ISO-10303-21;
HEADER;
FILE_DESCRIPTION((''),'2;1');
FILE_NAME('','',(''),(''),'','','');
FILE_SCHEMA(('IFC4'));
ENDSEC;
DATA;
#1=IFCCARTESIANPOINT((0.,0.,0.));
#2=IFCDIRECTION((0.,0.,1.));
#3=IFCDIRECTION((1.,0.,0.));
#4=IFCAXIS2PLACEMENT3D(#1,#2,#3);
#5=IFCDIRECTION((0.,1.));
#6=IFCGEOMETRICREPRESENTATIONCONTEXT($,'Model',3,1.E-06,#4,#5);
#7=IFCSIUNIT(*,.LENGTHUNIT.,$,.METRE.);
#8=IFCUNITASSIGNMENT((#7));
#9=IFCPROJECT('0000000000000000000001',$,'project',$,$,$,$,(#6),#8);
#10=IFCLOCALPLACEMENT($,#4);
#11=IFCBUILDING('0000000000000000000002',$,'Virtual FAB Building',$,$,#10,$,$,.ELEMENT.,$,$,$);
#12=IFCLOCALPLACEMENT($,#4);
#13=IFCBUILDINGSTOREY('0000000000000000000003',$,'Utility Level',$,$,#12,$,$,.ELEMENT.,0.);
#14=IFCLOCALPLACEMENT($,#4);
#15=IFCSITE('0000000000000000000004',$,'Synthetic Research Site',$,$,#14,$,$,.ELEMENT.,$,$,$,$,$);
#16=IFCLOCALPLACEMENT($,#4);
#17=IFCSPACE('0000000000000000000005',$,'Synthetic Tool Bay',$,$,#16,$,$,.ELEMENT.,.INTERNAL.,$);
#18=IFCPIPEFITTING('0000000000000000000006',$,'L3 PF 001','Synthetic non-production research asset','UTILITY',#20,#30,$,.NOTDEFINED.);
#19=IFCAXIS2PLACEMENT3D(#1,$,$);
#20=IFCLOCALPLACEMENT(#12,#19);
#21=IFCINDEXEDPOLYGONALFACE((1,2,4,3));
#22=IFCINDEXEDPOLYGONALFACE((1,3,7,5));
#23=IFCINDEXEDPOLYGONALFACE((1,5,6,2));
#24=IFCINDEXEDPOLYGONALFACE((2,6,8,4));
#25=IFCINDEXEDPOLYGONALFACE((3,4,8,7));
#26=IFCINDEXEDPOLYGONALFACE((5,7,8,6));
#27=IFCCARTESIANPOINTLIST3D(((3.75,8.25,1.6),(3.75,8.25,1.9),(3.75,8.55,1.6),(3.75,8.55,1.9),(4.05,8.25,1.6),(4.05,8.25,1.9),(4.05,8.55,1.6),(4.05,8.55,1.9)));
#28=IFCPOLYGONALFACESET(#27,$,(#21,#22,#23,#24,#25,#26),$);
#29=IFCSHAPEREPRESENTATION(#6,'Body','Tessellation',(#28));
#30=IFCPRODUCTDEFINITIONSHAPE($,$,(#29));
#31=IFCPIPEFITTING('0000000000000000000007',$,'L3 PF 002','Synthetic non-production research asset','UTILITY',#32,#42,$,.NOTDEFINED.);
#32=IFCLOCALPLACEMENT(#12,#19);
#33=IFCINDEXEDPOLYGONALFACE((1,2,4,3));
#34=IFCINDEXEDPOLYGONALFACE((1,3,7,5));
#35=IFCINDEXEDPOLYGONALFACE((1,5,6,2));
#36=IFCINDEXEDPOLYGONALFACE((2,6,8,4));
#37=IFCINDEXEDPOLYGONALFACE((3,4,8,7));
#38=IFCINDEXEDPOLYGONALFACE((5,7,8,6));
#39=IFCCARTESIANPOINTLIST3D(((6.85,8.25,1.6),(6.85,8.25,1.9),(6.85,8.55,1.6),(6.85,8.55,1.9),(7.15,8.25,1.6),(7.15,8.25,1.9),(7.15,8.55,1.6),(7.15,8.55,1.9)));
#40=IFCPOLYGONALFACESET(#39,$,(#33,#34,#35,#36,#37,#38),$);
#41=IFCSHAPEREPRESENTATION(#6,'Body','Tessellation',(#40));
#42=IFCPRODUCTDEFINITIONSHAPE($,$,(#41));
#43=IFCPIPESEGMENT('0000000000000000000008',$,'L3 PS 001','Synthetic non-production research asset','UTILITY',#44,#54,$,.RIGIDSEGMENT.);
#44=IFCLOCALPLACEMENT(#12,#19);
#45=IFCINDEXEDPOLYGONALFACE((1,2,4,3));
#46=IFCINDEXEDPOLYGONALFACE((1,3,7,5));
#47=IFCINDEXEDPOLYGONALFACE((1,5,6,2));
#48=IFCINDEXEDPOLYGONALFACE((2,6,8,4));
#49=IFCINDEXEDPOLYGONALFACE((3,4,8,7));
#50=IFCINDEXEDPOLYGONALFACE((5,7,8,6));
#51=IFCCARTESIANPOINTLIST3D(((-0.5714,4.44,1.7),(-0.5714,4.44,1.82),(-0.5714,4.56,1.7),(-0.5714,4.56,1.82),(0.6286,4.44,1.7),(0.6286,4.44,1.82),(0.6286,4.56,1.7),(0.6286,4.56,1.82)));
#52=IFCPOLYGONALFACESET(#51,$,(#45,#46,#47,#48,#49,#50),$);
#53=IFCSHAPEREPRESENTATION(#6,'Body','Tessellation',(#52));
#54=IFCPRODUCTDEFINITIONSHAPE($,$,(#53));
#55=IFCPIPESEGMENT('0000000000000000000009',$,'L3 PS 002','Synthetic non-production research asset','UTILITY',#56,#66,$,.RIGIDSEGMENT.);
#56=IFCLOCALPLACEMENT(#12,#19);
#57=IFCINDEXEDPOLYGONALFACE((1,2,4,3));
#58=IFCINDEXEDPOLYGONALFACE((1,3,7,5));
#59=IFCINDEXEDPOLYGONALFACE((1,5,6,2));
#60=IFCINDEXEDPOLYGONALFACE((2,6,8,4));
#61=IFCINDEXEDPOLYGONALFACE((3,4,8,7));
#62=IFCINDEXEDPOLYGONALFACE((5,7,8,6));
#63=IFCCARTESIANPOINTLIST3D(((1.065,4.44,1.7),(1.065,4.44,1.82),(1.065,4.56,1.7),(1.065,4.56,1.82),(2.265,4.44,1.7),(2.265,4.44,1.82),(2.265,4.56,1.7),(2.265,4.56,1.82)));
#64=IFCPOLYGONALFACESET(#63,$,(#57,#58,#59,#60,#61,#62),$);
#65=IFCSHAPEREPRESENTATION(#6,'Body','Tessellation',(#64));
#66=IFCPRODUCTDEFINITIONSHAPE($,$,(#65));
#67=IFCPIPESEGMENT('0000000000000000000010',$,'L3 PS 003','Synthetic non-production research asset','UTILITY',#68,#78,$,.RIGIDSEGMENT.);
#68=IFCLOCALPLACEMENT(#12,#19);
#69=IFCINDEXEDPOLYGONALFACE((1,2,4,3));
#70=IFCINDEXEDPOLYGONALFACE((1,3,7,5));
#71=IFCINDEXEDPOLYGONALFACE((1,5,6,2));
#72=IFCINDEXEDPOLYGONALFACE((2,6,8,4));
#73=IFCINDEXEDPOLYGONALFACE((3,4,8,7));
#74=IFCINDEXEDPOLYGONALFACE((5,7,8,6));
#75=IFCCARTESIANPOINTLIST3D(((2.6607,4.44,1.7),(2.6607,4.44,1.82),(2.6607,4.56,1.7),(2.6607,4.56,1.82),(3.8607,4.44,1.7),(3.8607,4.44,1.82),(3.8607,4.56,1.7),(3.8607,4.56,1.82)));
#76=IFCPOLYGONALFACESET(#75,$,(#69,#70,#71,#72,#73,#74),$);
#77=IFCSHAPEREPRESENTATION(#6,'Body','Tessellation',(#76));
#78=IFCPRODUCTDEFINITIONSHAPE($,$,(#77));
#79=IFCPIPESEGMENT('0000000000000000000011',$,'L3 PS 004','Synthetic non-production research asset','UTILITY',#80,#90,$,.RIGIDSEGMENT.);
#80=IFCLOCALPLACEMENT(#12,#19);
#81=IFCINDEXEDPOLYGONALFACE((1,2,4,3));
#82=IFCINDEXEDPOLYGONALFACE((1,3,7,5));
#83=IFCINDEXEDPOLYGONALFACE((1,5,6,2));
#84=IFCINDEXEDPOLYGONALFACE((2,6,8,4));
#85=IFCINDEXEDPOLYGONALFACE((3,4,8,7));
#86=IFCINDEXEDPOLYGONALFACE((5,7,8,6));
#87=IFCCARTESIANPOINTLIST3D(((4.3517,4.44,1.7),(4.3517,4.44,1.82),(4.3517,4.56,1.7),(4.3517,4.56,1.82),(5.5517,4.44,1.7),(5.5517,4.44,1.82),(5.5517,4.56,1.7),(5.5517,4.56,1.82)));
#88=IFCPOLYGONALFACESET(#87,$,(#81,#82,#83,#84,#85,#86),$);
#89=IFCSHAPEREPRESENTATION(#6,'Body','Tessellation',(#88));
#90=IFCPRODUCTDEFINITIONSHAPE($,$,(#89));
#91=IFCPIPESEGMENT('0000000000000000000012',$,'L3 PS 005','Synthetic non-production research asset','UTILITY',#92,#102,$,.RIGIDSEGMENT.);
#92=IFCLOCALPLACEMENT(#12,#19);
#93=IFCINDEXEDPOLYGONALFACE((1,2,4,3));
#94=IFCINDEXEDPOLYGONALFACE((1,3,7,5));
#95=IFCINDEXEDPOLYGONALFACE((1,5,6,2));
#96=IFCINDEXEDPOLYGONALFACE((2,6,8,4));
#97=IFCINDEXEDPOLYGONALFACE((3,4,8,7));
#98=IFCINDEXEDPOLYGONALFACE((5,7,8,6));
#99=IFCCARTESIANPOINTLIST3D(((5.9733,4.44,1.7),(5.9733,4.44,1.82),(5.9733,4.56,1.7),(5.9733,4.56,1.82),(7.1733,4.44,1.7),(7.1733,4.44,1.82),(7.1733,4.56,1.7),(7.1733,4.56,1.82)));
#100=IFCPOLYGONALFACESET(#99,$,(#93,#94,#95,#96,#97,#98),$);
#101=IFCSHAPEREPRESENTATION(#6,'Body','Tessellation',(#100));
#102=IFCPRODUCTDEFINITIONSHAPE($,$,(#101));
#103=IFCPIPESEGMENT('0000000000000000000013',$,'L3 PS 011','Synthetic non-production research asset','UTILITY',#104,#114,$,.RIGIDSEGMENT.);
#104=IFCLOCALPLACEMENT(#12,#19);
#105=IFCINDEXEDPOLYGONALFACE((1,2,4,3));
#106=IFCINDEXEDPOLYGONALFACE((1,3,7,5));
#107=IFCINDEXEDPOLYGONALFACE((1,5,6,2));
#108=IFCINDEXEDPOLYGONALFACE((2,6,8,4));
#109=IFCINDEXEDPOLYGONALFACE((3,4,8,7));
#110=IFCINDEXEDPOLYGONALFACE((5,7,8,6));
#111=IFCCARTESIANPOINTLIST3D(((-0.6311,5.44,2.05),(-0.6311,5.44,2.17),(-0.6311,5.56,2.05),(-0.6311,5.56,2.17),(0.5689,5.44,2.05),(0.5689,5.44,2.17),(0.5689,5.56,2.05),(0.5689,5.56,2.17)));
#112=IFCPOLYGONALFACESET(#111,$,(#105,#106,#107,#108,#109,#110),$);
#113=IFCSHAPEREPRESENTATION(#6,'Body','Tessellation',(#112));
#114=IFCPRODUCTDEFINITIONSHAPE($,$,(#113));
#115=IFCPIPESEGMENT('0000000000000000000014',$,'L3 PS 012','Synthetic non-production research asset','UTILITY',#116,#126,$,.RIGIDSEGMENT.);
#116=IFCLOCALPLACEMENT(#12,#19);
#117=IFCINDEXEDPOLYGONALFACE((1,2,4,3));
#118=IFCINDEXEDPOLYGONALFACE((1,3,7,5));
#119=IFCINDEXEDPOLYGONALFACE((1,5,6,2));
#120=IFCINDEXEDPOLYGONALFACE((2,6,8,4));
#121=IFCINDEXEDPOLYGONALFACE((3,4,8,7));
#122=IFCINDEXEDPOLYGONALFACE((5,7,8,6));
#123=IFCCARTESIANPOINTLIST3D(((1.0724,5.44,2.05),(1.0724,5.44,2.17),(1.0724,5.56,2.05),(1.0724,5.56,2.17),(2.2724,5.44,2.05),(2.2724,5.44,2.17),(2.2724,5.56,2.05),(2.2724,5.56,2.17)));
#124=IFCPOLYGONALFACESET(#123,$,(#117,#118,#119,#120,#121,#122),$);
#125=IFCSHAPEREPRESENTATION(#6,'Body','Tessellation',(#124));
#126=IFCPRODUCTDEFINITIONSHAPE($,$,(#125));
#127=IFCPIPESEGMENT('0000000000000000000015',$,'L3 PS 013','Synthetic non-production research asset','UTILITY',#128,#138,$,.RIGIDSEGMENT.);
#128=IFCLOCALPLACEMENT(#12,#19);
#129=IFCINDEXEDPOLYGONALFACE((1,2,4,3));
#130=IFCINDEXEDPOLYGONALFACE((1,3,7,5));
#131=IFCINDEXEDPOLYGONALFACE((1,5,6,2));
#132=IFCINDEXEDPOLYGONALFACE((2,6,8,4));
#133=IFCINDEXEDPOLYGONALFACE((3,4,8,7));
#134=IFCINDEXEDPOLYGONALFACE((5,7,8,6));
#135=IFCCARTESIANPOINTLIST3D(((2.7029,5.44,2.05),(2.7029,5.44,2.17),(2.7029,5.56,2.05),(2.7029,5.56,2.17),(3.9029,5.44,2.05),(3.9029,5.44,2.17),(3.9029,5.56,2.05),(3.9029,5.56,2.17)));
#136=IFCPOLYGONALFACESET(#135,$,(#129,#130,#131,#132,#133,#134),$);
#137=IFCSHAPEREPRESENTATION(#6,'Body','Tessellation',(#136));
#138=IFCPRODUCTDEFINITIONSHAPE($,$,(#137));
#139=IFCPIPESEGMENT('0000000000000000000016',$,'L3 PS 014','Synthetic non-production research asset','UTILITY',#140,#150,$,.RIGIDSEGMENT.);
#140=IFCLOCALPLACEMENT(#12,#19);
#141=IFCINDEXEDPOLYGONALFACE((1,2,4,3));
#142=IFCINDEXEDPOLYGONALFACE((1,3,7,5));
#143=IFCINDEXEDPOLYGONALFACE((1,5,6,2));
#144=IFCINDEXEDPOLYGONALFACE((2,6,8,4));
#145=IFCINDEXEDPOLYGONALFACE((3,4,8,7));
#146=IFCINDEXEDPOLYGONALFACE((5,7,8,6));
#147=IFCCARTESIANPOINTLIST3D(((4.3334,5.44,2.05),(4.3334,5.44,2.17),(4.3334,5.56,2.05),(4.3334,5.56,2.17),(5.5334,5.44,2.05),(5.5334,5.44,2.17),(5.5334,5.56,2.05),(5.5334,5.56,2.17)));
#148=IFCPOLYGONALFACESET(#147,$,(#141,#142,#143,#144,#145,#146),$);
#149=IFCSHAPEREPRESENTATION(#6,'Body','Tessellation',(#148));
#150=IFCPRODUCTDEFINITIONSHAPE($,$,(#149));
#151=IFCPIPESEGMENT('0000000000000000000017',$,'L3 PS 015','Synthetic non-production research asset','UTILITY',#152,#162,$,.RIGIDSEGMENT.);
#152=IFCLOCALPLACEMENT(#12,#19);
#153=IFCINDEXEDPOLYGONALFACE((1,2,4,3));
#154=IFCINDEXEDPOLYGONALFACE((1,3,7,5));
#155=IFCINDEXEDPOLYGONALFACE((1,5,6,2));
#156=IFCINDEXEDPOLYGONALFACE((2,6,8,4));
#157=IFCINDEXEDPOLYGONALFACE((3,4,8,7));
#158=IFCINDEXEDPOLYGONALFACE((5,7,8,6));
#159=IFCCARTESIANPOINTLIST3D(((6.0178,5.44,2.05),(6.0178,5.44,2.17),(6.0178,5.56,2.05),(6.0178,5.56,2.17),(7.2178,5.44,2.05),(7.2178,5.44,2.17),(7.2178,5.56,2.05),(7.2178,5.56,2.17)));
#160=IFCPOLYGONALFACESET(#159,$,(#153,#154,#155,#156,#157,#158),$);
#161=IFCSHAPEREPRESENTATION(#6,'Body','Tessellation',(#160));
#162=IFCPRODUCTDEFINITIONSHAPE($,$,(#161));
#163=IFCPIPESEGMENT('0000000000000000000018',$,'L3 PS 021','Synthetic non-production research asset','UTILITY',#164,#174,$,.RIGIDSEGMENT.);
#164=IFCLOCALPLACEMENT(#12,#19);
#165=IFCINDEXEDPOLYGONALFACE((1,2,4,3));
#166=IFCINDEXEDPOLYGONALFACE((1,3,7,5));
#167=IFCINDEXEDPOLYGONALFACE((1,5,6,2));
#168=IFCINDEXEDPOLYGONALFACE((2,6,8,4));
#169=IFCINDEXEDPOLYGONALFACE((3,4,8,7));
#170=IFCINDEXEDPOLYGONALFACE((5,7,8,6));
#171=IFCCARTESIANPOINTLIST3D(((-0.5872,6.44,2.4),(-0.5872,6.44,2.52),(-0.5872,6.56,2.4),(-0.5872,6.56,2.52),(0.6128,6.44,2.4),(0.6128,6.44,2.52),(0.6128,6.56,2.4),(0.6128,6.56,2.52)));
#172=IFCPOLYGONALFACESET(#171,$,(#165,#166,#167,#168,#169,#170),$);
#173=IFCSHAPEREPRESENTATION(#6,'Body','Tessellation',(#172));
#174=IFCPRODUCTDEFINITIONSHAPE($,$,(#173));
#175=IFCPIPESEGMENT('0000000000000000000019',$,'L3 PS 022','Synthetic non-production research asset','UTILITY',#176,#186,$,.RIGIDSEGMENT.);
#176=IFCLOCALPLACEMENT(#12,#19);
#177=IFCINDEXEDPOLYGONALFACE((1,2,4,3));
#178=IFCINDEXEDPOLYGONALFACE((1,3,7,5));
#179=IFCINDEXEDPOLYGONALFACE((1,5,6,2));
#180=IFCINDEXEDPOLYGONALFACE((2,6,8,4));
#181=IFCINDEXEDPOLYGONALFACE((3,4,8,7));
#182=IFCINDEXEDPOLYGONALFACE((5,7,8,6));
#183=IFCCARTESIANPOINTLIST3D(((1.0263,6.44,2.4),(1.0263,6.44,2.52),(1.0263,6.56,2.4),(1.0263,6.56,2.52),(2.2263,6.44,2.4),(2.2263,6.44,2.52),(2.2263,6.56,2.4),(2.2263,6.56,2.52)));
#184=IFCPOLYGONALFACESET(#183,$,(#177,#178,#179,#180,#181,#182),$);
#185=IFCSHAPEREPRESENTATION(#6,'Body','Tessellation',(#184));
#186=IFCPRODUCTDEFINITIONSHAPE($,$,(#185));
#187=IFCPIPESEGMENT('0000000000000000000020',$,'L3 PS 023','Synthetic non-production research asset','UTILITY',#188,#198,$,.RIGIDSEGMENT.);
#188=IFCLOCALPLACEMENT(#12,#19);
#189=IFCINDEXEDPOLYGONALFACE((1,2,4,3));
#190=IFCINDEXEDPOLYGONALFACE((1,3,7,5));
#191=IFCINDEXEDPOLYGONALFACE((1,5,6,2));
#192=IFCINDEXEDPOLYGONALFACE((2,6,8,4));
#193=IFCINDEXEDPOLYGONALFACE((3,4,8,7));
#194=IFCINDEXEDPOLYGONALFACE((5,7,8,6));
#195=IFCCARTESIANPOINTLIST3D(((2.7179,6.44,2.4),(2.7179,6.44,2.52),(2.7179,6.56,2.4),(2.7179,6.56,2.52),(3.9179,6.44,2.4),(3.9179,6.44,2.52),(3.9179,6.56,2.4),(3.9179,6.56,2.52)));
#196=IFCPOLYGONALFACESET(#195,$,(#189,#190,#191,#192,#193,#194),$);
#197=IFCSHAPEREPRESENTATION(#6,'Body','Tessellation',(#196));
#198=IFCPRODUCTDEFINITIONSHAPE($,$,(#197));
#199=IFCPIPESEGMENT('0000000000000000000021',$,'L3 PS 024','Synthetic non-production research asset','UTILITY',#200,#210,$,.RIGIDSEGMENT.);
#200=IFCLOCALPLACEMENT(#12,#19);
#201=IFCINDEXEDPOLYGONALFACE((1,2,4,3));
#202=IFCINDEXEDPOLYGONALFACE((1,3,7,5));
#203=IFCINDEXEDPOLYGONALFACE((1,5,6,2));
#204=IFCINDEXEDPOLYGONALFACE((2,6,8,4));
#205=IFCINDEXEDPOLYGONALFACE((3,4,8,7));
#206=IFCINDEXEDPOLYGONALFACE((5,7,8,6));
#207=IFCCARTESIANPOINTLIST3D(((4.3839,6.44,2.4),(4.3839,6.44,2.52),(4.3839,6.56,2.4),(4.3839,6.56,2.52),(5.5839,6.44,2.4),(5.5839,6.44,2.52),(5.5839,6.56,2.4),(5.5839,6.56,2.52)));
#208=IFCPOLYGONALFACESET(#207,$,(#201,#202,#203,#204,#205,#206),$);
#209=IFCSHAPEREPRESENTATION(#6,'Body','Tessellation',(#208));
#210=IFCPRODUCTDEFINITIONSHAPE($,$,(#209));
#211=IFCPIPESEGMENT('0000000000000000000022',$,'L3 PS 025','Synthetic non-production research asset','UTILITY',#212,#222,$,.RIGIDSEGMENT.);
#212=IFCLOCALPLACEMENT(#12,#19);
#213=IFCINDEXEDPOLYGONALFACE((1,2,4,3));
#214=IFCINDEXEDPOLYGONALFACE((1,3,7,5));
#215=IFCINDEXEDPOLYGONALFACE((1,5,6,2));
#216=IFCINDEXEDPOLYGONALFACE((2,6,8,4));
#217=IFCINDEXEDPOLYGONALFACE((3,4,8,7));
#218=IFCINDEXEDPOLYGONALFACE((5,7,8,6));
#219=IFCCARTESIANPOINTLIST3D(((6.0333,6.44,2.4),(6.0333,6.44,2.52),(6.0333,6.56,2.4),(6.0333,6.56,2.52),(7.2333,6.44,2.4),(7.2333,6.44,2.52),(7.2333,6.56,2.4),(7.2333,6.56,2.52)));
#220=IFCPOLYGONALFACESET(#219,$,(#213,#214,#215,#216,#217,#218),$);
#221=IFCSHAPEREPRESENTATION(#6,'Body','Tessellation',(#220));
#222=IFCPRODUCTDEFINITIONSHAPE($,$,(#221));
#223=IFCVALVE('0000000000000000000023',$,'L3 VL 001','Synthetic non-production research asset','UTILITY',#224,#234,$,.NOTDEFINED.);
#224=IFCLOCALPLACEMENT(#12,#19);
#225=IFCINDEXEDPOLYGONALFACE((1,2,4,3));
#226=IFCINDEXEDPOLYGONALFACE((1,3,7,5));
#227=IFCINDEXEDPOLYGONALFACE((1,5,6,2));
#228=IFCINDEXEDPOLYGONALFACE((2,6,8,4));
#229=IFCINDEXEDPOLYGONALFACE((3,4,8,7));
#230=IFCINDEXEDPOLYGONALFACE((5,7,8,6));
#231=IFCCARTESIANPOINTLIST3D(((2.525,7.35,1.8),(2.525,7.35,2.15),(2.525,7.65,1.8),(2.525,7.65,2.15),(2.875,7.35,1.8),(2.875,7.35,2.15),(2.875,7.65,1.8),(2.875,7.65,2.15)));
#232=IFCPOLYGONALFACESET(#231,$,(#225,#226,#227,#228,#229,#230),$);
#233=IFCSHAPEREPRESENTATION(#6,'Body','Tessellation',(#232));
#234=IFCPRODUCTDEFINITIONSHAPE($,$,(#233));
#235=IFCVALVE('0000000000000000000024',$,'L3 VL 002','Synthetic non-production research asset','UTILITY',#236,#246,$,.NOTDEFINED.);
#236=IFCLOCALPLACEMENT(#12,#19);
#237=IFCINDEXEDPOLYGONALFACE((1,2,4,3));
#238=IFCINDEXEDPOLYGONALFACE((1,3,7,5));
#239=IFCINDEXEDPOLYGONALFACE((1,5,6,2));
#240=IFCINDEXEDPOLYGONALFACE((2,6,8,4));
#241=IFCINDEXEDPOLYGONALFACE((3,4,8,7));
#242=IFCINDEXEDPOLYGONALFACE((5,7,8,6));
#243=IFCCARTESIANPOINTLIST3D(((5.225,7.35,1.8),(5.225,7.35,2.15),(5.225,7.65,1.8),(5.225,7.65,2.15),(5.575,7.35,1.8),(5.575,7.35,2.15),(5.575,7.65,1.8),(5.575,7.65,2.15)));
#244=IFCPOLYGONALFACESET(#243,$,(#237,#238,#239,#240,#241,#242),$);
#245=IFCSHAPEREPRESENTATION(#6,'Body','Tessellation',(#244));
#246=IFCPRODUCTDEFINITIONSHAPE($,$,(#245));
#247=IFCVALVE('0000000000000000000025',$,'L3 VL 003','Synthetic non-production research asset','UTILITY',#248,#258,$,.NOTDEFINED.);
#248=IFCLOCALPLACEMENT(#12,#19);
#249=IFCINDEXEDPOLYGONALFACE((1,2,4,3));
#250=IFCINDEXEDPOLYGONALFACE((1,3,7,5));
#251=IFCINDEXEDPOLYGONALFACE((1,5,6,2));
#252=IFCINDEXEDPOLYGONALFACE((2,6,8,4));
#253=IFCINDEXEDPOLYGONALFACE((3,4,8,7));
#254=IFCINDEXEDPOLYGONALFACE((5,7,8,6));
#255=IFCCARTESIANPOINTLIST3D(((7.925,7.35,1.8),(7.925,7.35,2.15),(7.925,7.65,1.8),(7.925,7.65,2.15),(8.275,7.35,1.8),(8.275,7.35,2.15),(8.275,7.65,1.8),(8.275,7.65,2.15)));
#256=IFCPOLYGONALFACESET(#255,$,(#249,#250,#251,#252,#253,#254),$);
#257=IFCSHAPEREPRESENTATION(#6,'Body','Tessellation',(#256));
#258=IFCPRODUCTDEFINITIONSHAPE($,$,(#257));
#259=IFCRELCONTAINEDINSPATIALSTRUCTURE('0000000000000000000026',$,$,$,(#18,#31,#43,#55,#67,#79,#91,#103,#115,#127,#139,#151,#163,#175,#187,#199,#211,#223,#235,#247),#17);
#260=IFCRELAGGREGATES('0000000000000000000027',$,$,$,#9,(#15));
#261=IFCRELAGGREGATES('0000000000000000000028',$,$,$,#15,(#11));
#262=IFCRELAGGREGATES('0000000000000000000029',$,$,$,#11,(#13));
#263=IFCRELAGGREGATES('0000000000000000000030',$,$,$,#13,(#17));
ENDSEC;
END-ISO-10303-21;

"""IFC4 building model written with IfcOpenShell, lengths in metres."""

from ifc_helpers import new_model, si_unit, direction, frame, origin_with_axes, origin_2d_with_axis, place, context, project, spatial, rectangle, extrude, element, save


model = new_model("IFC4")

# Units and contexts
model_context = context("Model", 3, precision=1e-06, world=origin_with_axes(), true_north=direction((0.0, 1.0)))
ifc_project = project(units=[si_unit("LENGTHUNIT", "METRE")], contexts=[model_context])

# Site, building, storey, space
site_placement = place(None, origin_with_axes())
site = spatial("IfcSite", under=ifc_project, at=site_placement, Name="Synthetic Research Site", CompositionType="ELEMENT")
building_placement = place(None, origin_with_axes())
building = spatial("IfcBuilding", under=site, at=building_placement, Name="Virtual FAB Building", CompositionType="ELEMENT")
storey_placement = place(None, origin_with_axes())
storey = spatial("IfcBuildingStorey", under=building, at=storey_placement, Name="Utility Level", CompositionType="ELEMENT", Elevation=0.0)
space_placement = place(None, origin_with_axes())
space = spatial("IfcSpace", under=storey, at=space_placement, Name="Synthetic Tool Bay", CompositionType="ELEMENT", PredefinedType="INTERNAL")

# Pipe fittings
for number, where, z_axis, x_axis, name in (
    (1, (3.9, 8.4, 1.6), (0.0, 0.0, 1.0), (1.0, 0.0, 0.0), "L3 PF 001"),
    (2, (7.0, 8.4, 1.6), (0.0, 0.0, 1.0), (1.0, 0.0, 0.0), "L3 PF 002"),
):
    element("IfcPipeFitting", number, at=place(None, frame(where, z_axis=z_axis, x_axis=x_axis)), inside=space, Name=name, Description="Synthetic non-production research asset", ObjectType="UTILITY", PredefinedType="NOTDEFINED", context=model_context, shape_type="SweptSolid", body=[
        extrude(rectangle(XDim=0.3, YDim=0.3, at=origin_2d_with_axis()), origin_with_axes(), (0.0, 0.0, 1.0), 0.3),
    ])

# Pipe segments
for number, where, z_axis, x_axis, name in (
    (3, (0.0286, 4.5, 1.7), (0.0, 0.0, 1.0), (1.0, 0.0, 0.0), "L3 PS 001"),
    (4, (1.665, 4.5, 1.7), (0.0, 0.0, 1.0), (1.0, 0.0, 0.0), "L3 PS 002"),
    (5, (3.2607, 4.5, 1.7), (0.0, 0.0, 1.0), (1.0, 0.0, 0.0), "L3 PS 003"),
    (6, (4.9517, 4.5, 1.7), (0.0, 0.0, 1.0), (1.0, 0.0, 0.0), "L3 PS 004"),
    (7, (6.5733, 4.5, 1.7), (0.0, 0.0, 1.0), (1.0, 0.0, 0.0), "L3 PS 005"),
    (8, (-0.0311, 5.5, 2.05), (0.0, 0.0, 1.0), (1.0, 0.0, 0.0), "L3 PS 011"),
    (9, (1.6724, 5.5, 2.05), (0.0, 0.0, 1.0), (1.0, 0.0, 0.0), "L3 PS 012"),
    (10, (3.3029, 5.5, 2.05), (0.0, 0.0, 1.0), (1.0, 0.0, 0.0), "L3 PS 013"),
    (11, (4.9334, 5.5, 2.05), (0.0, 0.0, 1.0), (1.0, 0.0, 0.0), "L3 PS 014"),
    (12, (6.6178, 5.5, 2.05), (0.0, 0.0, 1.0), (1.0, 0.0, 0.0), "L3 PS 015"),
    (13, (0.0128, 6.5, 2.4), (0.0, 0.0, 1.0), (1.0, 0.0, 0.0), "L3 PS 021"),
    (14, (1.6263, 6.5, 2.4), (0.0, 0.0, 1.0), (1.0, 0.0, 0.0), "L3 PS 022"),
    (15, (3.3179, 6.5, 2.4), (0.0, 0.0, 1.0), (1.0, 0.0, 0.0), "L3 PS 023"),
    (16, (4.9839, 6.5, 2.4), (0.0, 0.0, 1.0), (1.0, 0.0, 0.0), "L3 PS 024"),
    (17, (6.6333, 6.5, 2.4), (0.0, 0.0, 1.0), (1.0, 0.0, 0.0), "L3 PS 025"),
):
    element("IfcPipeSegment", number, at=place(None, frame(where, z_axis=z_axis, x_axis=x_axis)), inside=space, Name=name, Description="Synthetic non-production research asset", ObjectType="UTILITY", PredefinedType="RIGIDSEGMENT", context=model_context, shape_type="SweptSolid", body=[
        extrude(rectangle(XDim=1.2, YDim=0.12, at=origin_2d_with_axis()), origin_with_axes(), (0.0, 0.0, 1.0), 0.12),
    ])

# Valves
for number, where, z_axis, x_axis, name in (
    (18, (2.7, 7.5, 1.8), (0.0, 0.0, 1.0), (1.0, 0.0, 0.0), "L3 VL 001"),
    (19, (5.4, 7.5, 1.8), (0.0, 0.0, 1.0), (1.0, 0.0, 0.0), "L3 VL 002"),
    (20, (8.1, 7.5, 1.8), (0.0, 0.0, 1.0), (1.0, 0.0, 0.0), "L3 VL 003"),
):
    element("IfcValve", number, at=place(None, frame(where, z_axis=z_axis, x_axis=x_axis)), inside=space, Name=name, Description="Synthetic non-production research asset", ObjectType="UTILITY", PredefinedType="NOTDEFINED", context=model_context, shape_type="SweptSolid", body=[
        extrude(rectangle(XDim=0.35, YDim=0.3, at=origin_2d_with_axis()), origin_with_axes(), (0.0, 0.0, 1.0), 0.35),
    ])

save(model, "model.ifc")
